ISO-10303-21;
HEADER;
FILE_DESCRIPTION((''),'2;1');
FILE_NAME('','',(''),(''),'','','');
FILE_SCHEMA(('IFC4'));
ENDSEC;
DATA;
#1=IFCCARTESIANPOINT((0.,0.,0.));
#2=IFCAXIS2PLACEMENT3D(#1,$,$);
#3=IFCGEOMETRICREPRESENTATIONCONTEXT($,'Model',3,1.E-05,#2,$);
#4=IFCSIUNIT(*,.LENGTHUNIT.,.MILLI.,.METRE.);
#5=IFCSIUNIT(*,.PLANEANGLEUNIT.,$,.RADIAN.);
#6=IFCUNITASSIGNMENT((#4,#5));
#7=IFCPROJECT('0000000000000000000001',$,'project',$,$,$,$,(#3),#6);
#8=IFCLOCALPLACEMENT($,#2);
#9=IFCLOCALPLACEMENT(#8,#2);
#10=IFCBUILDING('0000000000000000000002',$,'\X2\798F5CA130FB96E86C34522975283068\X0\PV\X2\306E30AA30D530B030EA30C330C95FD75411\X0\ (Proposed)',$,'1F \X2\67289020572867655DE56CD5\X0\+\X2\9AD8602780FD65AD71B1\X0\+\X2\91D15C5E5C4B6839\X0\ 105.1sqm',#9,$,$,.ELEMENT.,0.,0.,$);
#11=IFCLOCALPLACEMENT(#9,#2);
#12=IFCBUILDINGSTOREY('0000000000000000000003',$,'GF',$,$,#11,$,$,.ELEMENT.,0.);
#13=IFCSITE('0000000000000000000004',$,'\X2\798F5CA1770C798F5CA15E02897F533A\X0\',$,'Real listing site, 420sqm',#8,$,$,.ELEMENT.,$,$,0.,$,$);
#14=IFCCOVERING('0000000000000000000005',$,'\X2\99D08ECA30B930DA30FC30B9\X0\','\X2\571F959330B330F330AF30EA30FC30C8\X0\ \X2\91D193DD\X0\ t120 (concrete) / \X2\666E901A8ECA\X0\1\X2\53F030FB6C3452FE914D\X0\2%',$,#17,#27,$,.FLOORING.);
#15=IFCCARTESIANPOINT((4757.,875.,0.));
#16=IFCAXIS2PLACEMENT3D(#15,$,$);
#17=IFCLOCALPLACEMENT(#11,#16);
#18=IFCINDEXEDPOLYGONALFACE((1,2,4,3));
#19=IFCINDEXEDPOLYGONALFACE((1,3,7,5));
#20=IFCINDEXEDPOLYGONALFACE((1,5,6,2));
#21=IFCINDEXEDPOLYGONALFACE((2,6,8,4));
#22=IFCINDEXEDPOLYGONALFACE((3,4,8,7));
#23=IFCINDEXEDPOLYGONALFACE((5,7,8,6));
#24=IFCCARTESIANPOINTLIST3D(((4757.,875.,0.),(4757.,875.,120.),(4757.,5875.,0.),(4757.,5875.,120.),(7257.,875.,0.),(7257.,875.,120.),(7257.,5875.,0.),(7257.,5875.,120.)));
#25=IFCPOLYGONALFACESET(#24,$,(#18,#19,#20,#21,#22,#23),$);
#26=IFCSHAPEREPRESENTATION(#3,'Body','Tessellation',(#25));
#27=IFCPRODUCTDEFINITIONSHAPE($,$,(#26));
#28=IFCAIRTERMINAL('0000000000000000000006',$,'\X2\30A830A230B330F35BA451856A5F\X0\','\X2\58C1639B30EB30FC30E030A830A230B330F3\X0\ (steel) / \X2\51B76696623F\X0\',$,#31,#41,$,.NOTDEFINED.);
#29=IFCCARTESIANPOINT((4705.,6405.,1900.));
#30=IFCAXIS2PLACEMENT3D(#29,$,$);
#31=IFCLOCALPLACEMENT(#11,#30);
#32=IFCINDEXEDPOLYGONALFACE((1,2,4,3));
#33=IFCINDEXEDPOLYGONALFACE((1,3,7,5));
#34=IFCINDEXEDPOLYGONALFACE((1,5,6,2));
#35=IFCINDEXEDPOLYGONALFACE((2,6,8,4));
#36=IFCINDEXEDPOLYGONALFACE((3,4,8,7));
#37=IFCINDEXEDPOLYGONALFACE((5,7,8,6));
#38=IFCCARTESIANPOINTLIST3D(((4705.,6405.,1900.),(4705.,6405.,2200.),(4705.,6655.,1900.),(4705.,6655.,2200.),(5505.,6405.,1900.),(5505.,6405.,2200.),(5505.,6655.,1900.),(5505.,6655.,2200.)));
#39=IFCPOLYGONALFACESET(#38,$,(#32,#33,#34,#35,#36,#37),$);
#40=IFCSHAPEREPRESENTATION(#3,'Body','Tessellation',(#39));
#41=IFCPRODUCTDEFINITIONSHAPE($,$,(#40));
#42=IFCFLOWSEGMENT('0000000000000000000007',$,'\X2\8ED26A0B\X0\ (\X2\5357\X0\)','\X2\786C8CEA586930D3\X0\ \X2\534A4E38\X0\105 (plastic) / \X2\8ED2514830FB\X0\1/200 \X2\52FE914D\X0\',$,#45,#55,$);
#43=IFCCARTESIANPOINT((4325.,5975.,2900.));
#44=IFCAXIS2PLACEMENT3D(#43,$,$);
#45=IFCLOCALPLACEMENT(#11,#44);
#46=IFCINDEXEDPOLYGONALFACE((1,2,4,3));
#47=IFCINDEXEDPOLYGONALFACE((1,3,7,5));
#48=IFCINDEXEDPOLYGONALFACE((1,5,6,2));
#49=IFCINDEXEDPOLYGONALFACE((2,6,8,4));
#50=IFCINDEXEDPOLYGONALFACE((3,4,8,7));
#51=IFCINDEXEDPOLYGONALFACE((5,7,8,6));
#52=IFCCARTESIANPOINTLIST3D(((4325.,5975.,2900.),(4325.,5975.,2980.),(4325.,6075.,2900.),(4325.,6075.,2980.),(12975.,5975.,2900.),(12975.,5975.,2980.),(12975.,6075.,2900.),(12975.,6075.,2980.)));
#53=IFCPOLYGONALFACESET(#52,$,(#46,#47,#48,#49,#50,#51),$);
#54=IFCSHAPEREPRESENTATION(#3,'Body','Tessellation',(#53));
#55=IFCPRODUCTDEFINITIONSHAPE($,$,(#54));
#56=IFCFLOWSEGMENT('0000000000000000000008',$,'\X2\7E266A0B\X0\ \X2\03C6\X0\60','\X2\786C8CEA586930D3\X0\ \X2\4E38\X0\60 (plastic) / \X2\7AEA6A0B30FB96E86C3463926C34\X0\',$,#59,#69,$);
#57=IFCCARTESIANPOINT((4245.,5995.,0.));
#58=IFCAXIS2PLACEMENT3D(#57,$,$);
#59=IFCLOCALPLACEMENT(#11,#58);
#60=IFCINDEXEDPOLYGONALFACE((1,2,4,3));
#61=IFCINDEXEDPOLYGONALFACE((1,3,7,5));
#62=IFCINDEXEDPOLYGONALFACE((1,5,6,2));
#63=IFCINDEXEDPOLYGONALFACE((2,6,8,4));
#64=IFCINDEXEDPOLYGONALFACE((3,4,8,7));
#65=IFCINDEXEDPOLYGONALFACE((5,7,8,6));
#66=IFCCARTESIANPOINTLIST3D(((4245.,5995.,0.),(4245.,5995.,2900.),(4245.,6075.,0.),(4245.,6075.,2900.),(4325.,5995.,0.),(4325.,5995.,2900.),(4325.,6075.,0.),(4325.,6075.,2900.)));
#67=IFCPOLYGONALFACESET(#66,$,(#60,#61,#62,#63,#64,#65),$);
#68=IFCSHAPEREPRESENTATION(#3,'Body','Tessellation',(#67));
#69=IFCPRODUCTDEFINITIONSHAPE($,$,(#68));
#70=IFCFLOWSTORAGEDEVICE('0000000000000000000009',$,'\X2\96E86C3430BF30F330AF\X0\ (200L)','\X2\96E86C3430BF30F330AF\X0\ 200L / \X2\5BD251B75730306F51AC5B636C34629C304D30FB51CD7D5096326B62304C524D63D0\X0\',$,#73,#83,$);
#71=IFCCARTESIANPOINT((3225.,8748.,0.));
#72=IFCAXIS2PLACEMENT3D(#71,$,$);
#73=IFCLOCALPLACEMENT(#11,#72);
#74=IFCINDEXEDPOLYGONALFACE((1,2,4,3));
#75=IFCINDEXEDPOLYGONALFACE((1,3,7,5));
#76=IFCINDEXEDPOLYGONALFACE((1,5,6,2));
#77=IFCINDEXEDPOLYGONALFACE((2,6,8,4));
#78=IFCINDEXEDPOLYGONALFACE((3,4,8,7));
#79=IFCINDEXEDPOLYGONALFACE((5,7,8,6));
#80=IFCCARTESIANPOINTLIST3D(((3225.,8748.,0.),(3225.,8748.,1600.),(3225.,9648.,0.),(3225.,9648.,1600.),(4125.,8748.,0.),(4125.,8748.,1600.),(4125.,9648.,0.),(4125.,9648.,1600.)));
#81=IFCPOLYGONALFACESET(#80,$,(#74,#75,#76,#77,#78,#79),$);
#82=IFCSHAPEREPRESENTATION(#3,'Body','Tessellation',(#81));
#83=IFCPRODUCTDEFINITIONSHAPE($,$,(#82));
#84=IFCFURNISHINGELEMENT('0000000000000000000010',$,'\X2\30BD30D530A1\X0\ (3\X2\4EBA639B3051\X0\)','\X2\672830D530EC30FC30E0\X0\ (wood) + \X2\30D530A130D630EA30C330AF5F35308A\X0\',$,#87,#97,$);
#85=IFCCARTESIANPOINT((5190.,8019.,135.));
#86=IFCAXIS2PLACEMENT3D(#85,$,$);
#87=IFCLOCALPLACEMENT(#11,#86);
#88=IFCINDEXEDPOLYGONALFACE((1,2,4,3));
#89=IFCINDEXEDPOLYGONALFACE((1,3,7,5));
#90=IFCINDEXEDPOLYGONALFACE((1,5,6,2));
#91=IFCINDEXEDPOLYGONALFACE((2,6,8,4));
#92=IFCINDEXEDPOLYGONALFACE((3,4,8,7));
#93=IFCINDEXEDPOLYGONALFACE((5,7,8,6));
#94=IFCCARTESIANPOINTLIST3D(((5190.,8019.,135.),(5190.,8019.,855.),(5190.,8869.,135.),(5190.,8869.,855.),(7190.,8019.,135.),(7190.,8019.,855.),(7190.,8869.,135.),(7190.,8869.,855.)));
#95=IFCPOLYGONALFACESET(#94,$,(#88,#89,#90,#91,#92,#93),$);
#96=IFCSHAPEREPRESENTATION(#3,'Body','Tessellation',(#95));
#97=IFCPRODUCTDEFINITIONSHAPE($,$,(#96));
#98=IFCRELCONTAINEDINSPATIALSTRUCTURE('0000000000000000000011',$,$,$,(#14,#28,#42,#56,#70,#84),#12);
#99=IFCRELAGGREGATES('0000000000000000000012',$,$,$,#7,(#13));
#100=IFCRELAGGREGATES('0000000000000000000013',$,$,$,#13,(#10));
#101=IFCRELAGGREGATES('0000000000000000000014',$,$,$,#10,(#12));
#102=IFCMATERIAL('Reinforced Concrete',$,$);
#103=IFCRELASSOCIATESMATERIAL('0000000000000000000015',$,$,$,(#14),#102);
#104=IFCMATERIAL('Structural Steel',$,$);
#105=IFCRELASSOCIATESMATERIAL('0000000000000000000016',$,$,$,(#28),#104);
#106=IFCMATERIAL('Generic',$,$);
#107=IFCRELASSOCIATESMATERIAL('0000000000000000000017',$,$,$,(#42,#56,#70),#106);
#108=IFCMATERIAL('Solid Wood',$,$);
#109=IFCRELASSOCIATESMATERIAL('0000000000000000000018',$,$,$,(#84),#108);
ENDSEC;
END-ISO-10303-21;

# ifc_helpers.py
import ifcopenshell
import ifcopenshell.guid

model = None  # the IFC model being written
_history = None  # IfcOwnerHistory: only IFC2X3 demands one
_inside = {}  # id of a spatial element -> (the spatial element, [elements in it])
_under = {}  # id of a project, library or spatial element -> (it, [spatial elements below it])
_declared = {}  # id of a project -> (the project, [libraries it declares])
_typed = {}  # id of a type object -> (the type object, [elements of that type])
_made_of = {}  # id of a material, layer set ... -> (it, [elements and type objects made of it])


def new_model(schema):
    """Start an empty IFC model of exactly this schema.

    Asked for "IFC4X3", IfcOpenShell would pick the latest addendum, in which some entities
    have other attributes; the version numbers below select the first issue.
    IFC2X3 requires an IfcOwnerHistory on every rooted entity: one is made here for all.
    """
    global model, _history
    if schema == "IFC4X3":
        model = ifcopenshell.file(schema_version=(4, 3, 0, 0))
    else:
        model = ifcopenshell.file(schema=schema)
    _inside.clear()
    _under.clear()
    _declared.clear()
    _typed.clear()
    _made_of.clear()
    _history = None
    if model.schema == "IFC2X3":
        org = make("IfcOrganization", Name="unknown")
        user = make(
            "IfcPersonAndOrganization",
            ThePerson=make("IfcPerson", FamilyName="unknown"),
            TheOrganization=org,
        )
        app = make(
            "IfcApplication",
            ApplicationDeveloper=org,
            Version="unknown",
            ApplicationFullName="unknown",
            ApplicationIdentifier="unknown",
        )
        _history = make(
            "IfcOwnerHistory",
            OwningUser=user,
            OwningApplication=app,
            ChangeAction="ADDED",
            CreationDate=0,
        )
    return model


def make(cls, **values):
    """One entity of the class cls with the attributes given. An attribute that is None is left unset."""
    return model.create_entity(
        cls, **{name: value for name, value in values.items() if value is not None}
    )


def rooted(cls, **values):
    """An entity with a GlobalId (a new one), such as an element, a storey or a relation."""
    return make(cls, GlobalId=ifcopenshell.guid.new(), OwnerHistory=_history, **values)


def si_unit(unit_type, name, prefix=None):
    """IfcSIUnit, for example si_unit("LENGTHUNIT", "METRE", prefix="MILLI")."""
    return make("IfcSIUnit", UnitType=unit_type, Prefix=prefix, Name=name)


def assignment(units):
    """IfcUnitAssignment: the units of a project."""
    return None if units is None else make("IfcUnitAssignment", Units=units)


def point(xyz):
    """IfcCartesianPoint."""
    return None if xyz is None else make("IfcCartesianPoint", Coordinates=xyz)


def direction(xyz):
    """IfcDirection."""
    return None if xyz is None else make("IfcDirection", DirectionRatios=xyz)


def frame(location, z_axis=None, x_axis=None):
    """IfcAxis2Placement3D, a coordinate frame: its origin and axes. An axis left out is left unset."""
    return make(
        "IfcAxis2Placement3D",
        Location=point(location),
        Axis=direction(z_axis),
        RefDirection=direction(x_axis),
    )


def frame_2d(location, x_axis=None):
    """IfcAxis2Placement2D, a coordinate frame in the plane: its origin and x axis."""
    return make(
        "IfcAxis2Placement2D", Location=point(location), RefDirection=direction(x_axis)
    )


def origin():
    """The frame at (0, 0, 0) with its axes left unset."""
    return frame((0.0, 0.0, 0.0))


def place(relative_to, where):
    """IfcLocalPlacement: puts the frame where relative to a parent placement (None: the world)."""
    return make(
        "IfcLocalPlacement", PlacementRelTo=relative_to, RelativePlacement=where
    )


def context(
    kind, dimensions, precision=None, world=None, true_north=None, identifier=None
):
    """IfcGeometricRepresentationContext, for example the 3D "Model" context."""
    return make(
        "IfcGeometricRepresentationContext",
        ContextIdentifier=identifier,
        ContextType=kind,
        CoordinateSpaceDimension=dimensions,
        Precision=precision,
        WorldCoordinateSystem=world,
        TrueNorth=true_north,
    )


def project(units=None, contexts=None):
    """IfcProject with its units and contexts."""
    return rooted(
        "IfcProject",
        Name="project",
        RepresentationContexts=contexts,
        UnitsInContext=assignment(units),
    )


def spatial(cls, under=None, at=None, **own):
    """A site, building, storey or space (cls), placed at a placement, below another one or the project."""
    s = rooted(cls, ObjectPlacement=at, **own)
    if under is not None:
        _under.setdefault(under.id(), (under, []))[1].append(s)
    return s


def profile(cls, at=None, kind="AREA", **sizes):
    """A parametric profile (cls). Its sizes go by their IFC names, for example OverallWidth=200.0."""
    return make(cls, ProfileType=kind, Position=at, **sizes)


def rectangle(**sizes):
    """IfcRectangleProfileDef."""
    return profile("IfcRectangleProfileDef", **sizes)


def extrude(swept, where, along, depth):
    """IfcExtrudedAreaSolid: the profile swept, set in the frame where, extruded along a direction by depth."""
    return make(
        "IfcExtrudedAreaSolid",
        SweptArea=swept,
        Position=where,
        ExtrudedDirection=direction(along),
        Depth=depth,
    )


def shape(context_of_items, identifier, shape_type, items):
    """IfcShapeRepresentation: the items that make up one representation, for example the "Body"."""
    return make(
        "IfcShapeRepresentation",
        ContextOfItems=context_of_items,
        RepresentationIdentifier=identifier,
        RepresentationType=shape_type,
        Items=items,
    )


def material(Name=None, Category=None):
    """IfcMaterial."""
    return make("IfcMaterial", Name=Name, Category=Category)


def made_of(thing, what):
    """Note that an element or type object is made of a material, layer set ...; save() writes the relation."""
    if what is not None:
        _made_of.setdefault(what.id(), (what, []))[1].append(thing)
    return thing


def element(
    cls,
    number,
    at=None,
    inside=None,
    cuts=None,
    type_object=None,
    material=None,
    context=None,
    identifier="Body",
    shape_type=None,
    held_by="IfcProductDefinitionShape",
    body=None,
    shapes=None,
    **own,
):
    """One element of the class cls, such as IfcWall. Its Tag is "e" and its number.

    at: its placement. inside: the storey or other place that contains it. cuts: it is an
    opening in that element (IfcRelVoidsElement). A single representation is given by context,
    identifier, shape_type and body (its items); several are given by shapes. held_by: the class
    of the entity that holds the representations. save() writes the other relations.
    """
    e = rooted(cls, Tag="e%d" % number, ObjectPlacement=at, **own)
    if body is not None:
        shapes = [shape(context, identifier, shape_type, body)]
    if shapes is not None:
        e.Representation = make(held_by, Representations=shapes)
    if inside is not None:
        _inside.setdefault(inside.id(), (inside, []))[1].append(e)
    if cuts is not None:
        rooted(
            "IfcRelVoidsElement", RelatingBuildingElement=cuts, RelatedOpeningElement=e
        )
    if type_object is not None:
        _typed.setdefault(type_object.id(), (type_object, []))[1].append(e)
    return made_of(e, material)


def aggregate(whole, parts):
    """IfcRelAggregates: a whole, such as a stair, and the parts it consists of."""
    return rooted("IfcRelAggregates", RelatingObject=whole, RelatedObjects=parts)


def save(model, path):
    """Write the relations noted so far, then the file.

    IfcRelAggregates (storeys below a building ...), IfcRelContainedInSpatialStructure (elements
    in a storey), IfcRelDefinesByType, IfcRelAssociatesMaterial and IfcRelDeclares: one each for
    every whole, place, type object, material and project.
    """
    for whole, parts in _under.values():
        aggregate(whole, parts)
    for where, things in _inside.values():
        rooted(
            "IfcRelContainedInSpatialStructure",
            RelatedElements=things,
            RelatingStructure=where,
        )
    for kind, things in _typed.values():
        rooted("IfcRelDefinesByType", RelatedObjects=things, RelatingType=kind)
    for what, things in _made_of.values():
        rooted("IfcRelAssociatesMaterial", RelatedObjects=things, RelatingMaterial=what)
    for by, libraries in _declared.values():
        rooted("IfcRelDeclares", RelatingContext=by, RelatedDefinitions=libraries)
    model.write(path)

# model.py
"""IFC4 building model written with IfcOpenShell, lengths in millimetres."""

from ifc_helpers import new_model, si_unit, frame, frame_2d, origin, place, context, project, spatial, rectangle, extrude, material, element, save


model = new_model("IFC4")

# Units and contexts
model_context = context("Model", 3, precision=1e-05, world=origin())
ifc_project = project(units=[si_unit("LENGTHUNIT", "METRE", prefix="MILLI"), si_unit("PLANEANGLEUNIT", "RADIAN")], contexts=[model_context])

# Site, building, storey
site_placement = place(None, origin())
site = spatial("IfcSite", under=ifc_project, at=site_placement, Name="福岡県福岡市西区", ObjectType="Real listing site, 420sqm", CompositionType="ELEMENT", RefElevation=0.0)
building_placement = place(site_placement, origin())
building = spatial("IfcBuilding", under=site, at=building_placement, Name="福岡・雨水利用とPVのオフグリッド志向 (Proposed)", ObjectType="1F 木造在来工法+高性能断熱+金属屋根 105.1sqm", CompositionType="ELEMENT", ElevationOfRefHeight=0.0, ElevationOfTerrain=0.0)
storey_placement = place(building_placement, origin())
storey = spatial("IfcBuildingStorey", under=building, at=storey_placement, Name="GF", CompositionType="ELEMENT", Elevation=0.0)

# Shared definitions
ifc_material_1 = material(Name="Solid Wood")

# Shared definitions
ifc_material_2 = material(Name="Reinforced Concrete")

# Shared definitions
ifc_material_3 = material(Name="Structural Steel")

# Covering
ifc_material_4 = material(Name="Generic")
covering_1_placement = place(storey_placement, frame((4757.0, 875.0, 0.0)))
element("IfcCovering", 1, at=covering_1_placement, inside=storey, material=ifc_material_2, Name="駐車スペース", Description="土間コンクリート 金鏝 t120 (concrete) / 普通車1台・水勾配2%", PredefinedType="FLOORING", context=model_context, shape_type="SweptSolid", body=[
    extrude(rectangle(XDim=2500.0, YDim=5000.0, at=frame_2d((1250.0, 2500.0))), frame((4757.0, 875.0, 0.0)), (0.0, 0.0, 1.0), 120.0),
])

# Air terminal
air_terminal_placement = place(storey_placement, frame((4705.0, 6405.0, 1900.0)))
element("IfcAirTerminal", 2, at=air_terminal_placement, inside=storey, material=ifc_material_3, Name="エアコン室内機", Description="壁掛ルームエアコン (steel) / 冷暖房", PredefinedType="NOTDEFINED", context=model_context, shape_type="SweptSolid", body=[
    extrude(rectangle(XDim=800.0, YDim=250.0, at=frame_2d((400.0, 125.0))), frame((4705.0, 6405.0, 1900.0)), (0.0, 0.0, 1.0), 300.0),
])

# Flow segments
flow_segment_1_placement = place(storey_placement, frame((4325.0, 5975.0, 2900.0)))
element("IfcFlowSegment", 3, at=flow_segment_1_placement, inside=storey, material=ifc_material_4, Name="軒樋 (南)", Description="硬質塩ビ 半丸105 (plastic) / 軒先・1/200 勾配", context=model_context, shape_type="SweptSolid", body=[
    extrude(rectangle(XDim=8650.0, YDim=100.0, at=frame_2d((4325.0, 50.0))), frame((4325.0, 5975.0, 2900.0)), (0.0, 0.0, 1.0), 80.0),
])
flow_segment_2_placement = place(storey_placement, frame((4245.0, 5995.0, 0.0)))
element("IfcFlowSegment", 4, at=flow_segment_2_placement, inside=storey, material=ifc_material_4, Name="縦樋 φ60", Description="硬質塩ビ 丸60 (plastic) / 竪樋・雨水排水", context=model_context, shape_type="SweptSolid", body=[
    extrude(rectangle(XDim=80.0, YDim=80.0, at=frame_2d((40.0, 40.0))), frame((4245.0, 5995.0, 0.0)), (0.0, 0.0, 1.0), 2900.0),
])

# Flow storage device
flow_storage_device_placement = place(storey_placement, frame((3225.0, 8748.0, 0.0)))
element("IfcFlowStorageDevice", 5, at=flow_storage_device_placement, inside=storey, material=ifc_material_4, Name="雨水タンク (200L)", Description="雨水タンク 200L / 寒冷地は冬季水抜き・凍結防止が前提", context=model_context, shape_type="SweptSolid", body=[
    extrude(rectangle(XDim=900.0, YDim=900.0, at=frame_2d((450.0, 450.0))), frame((3225.0, 8748.0, 0.0)), (0.0, 0.0, 1.0), 1600.0),
])

# Furnishing element
furnishing_placement = place(storey_placement, frame((5190.0, 8019.0, 135.0)))
element("IfcFurnishingElement", 6, at=furnishing_placement, inside=storey, material=ifc_material_1, Name="ソファ (3人掛け)", Description="木フレーム (wood) + ファブリック張り", context=model_context, shape_type="SweptSolid", body=[
    extrude(rectangle(XDim=2000.0, YDim=850.0, at=frame_2d((1000.0, 425.0))), frame((5190.0, 8019.0, 135.0)), (0.0, 0.0, 1.0), 720.0),
])

save(model, "model.ifc")
